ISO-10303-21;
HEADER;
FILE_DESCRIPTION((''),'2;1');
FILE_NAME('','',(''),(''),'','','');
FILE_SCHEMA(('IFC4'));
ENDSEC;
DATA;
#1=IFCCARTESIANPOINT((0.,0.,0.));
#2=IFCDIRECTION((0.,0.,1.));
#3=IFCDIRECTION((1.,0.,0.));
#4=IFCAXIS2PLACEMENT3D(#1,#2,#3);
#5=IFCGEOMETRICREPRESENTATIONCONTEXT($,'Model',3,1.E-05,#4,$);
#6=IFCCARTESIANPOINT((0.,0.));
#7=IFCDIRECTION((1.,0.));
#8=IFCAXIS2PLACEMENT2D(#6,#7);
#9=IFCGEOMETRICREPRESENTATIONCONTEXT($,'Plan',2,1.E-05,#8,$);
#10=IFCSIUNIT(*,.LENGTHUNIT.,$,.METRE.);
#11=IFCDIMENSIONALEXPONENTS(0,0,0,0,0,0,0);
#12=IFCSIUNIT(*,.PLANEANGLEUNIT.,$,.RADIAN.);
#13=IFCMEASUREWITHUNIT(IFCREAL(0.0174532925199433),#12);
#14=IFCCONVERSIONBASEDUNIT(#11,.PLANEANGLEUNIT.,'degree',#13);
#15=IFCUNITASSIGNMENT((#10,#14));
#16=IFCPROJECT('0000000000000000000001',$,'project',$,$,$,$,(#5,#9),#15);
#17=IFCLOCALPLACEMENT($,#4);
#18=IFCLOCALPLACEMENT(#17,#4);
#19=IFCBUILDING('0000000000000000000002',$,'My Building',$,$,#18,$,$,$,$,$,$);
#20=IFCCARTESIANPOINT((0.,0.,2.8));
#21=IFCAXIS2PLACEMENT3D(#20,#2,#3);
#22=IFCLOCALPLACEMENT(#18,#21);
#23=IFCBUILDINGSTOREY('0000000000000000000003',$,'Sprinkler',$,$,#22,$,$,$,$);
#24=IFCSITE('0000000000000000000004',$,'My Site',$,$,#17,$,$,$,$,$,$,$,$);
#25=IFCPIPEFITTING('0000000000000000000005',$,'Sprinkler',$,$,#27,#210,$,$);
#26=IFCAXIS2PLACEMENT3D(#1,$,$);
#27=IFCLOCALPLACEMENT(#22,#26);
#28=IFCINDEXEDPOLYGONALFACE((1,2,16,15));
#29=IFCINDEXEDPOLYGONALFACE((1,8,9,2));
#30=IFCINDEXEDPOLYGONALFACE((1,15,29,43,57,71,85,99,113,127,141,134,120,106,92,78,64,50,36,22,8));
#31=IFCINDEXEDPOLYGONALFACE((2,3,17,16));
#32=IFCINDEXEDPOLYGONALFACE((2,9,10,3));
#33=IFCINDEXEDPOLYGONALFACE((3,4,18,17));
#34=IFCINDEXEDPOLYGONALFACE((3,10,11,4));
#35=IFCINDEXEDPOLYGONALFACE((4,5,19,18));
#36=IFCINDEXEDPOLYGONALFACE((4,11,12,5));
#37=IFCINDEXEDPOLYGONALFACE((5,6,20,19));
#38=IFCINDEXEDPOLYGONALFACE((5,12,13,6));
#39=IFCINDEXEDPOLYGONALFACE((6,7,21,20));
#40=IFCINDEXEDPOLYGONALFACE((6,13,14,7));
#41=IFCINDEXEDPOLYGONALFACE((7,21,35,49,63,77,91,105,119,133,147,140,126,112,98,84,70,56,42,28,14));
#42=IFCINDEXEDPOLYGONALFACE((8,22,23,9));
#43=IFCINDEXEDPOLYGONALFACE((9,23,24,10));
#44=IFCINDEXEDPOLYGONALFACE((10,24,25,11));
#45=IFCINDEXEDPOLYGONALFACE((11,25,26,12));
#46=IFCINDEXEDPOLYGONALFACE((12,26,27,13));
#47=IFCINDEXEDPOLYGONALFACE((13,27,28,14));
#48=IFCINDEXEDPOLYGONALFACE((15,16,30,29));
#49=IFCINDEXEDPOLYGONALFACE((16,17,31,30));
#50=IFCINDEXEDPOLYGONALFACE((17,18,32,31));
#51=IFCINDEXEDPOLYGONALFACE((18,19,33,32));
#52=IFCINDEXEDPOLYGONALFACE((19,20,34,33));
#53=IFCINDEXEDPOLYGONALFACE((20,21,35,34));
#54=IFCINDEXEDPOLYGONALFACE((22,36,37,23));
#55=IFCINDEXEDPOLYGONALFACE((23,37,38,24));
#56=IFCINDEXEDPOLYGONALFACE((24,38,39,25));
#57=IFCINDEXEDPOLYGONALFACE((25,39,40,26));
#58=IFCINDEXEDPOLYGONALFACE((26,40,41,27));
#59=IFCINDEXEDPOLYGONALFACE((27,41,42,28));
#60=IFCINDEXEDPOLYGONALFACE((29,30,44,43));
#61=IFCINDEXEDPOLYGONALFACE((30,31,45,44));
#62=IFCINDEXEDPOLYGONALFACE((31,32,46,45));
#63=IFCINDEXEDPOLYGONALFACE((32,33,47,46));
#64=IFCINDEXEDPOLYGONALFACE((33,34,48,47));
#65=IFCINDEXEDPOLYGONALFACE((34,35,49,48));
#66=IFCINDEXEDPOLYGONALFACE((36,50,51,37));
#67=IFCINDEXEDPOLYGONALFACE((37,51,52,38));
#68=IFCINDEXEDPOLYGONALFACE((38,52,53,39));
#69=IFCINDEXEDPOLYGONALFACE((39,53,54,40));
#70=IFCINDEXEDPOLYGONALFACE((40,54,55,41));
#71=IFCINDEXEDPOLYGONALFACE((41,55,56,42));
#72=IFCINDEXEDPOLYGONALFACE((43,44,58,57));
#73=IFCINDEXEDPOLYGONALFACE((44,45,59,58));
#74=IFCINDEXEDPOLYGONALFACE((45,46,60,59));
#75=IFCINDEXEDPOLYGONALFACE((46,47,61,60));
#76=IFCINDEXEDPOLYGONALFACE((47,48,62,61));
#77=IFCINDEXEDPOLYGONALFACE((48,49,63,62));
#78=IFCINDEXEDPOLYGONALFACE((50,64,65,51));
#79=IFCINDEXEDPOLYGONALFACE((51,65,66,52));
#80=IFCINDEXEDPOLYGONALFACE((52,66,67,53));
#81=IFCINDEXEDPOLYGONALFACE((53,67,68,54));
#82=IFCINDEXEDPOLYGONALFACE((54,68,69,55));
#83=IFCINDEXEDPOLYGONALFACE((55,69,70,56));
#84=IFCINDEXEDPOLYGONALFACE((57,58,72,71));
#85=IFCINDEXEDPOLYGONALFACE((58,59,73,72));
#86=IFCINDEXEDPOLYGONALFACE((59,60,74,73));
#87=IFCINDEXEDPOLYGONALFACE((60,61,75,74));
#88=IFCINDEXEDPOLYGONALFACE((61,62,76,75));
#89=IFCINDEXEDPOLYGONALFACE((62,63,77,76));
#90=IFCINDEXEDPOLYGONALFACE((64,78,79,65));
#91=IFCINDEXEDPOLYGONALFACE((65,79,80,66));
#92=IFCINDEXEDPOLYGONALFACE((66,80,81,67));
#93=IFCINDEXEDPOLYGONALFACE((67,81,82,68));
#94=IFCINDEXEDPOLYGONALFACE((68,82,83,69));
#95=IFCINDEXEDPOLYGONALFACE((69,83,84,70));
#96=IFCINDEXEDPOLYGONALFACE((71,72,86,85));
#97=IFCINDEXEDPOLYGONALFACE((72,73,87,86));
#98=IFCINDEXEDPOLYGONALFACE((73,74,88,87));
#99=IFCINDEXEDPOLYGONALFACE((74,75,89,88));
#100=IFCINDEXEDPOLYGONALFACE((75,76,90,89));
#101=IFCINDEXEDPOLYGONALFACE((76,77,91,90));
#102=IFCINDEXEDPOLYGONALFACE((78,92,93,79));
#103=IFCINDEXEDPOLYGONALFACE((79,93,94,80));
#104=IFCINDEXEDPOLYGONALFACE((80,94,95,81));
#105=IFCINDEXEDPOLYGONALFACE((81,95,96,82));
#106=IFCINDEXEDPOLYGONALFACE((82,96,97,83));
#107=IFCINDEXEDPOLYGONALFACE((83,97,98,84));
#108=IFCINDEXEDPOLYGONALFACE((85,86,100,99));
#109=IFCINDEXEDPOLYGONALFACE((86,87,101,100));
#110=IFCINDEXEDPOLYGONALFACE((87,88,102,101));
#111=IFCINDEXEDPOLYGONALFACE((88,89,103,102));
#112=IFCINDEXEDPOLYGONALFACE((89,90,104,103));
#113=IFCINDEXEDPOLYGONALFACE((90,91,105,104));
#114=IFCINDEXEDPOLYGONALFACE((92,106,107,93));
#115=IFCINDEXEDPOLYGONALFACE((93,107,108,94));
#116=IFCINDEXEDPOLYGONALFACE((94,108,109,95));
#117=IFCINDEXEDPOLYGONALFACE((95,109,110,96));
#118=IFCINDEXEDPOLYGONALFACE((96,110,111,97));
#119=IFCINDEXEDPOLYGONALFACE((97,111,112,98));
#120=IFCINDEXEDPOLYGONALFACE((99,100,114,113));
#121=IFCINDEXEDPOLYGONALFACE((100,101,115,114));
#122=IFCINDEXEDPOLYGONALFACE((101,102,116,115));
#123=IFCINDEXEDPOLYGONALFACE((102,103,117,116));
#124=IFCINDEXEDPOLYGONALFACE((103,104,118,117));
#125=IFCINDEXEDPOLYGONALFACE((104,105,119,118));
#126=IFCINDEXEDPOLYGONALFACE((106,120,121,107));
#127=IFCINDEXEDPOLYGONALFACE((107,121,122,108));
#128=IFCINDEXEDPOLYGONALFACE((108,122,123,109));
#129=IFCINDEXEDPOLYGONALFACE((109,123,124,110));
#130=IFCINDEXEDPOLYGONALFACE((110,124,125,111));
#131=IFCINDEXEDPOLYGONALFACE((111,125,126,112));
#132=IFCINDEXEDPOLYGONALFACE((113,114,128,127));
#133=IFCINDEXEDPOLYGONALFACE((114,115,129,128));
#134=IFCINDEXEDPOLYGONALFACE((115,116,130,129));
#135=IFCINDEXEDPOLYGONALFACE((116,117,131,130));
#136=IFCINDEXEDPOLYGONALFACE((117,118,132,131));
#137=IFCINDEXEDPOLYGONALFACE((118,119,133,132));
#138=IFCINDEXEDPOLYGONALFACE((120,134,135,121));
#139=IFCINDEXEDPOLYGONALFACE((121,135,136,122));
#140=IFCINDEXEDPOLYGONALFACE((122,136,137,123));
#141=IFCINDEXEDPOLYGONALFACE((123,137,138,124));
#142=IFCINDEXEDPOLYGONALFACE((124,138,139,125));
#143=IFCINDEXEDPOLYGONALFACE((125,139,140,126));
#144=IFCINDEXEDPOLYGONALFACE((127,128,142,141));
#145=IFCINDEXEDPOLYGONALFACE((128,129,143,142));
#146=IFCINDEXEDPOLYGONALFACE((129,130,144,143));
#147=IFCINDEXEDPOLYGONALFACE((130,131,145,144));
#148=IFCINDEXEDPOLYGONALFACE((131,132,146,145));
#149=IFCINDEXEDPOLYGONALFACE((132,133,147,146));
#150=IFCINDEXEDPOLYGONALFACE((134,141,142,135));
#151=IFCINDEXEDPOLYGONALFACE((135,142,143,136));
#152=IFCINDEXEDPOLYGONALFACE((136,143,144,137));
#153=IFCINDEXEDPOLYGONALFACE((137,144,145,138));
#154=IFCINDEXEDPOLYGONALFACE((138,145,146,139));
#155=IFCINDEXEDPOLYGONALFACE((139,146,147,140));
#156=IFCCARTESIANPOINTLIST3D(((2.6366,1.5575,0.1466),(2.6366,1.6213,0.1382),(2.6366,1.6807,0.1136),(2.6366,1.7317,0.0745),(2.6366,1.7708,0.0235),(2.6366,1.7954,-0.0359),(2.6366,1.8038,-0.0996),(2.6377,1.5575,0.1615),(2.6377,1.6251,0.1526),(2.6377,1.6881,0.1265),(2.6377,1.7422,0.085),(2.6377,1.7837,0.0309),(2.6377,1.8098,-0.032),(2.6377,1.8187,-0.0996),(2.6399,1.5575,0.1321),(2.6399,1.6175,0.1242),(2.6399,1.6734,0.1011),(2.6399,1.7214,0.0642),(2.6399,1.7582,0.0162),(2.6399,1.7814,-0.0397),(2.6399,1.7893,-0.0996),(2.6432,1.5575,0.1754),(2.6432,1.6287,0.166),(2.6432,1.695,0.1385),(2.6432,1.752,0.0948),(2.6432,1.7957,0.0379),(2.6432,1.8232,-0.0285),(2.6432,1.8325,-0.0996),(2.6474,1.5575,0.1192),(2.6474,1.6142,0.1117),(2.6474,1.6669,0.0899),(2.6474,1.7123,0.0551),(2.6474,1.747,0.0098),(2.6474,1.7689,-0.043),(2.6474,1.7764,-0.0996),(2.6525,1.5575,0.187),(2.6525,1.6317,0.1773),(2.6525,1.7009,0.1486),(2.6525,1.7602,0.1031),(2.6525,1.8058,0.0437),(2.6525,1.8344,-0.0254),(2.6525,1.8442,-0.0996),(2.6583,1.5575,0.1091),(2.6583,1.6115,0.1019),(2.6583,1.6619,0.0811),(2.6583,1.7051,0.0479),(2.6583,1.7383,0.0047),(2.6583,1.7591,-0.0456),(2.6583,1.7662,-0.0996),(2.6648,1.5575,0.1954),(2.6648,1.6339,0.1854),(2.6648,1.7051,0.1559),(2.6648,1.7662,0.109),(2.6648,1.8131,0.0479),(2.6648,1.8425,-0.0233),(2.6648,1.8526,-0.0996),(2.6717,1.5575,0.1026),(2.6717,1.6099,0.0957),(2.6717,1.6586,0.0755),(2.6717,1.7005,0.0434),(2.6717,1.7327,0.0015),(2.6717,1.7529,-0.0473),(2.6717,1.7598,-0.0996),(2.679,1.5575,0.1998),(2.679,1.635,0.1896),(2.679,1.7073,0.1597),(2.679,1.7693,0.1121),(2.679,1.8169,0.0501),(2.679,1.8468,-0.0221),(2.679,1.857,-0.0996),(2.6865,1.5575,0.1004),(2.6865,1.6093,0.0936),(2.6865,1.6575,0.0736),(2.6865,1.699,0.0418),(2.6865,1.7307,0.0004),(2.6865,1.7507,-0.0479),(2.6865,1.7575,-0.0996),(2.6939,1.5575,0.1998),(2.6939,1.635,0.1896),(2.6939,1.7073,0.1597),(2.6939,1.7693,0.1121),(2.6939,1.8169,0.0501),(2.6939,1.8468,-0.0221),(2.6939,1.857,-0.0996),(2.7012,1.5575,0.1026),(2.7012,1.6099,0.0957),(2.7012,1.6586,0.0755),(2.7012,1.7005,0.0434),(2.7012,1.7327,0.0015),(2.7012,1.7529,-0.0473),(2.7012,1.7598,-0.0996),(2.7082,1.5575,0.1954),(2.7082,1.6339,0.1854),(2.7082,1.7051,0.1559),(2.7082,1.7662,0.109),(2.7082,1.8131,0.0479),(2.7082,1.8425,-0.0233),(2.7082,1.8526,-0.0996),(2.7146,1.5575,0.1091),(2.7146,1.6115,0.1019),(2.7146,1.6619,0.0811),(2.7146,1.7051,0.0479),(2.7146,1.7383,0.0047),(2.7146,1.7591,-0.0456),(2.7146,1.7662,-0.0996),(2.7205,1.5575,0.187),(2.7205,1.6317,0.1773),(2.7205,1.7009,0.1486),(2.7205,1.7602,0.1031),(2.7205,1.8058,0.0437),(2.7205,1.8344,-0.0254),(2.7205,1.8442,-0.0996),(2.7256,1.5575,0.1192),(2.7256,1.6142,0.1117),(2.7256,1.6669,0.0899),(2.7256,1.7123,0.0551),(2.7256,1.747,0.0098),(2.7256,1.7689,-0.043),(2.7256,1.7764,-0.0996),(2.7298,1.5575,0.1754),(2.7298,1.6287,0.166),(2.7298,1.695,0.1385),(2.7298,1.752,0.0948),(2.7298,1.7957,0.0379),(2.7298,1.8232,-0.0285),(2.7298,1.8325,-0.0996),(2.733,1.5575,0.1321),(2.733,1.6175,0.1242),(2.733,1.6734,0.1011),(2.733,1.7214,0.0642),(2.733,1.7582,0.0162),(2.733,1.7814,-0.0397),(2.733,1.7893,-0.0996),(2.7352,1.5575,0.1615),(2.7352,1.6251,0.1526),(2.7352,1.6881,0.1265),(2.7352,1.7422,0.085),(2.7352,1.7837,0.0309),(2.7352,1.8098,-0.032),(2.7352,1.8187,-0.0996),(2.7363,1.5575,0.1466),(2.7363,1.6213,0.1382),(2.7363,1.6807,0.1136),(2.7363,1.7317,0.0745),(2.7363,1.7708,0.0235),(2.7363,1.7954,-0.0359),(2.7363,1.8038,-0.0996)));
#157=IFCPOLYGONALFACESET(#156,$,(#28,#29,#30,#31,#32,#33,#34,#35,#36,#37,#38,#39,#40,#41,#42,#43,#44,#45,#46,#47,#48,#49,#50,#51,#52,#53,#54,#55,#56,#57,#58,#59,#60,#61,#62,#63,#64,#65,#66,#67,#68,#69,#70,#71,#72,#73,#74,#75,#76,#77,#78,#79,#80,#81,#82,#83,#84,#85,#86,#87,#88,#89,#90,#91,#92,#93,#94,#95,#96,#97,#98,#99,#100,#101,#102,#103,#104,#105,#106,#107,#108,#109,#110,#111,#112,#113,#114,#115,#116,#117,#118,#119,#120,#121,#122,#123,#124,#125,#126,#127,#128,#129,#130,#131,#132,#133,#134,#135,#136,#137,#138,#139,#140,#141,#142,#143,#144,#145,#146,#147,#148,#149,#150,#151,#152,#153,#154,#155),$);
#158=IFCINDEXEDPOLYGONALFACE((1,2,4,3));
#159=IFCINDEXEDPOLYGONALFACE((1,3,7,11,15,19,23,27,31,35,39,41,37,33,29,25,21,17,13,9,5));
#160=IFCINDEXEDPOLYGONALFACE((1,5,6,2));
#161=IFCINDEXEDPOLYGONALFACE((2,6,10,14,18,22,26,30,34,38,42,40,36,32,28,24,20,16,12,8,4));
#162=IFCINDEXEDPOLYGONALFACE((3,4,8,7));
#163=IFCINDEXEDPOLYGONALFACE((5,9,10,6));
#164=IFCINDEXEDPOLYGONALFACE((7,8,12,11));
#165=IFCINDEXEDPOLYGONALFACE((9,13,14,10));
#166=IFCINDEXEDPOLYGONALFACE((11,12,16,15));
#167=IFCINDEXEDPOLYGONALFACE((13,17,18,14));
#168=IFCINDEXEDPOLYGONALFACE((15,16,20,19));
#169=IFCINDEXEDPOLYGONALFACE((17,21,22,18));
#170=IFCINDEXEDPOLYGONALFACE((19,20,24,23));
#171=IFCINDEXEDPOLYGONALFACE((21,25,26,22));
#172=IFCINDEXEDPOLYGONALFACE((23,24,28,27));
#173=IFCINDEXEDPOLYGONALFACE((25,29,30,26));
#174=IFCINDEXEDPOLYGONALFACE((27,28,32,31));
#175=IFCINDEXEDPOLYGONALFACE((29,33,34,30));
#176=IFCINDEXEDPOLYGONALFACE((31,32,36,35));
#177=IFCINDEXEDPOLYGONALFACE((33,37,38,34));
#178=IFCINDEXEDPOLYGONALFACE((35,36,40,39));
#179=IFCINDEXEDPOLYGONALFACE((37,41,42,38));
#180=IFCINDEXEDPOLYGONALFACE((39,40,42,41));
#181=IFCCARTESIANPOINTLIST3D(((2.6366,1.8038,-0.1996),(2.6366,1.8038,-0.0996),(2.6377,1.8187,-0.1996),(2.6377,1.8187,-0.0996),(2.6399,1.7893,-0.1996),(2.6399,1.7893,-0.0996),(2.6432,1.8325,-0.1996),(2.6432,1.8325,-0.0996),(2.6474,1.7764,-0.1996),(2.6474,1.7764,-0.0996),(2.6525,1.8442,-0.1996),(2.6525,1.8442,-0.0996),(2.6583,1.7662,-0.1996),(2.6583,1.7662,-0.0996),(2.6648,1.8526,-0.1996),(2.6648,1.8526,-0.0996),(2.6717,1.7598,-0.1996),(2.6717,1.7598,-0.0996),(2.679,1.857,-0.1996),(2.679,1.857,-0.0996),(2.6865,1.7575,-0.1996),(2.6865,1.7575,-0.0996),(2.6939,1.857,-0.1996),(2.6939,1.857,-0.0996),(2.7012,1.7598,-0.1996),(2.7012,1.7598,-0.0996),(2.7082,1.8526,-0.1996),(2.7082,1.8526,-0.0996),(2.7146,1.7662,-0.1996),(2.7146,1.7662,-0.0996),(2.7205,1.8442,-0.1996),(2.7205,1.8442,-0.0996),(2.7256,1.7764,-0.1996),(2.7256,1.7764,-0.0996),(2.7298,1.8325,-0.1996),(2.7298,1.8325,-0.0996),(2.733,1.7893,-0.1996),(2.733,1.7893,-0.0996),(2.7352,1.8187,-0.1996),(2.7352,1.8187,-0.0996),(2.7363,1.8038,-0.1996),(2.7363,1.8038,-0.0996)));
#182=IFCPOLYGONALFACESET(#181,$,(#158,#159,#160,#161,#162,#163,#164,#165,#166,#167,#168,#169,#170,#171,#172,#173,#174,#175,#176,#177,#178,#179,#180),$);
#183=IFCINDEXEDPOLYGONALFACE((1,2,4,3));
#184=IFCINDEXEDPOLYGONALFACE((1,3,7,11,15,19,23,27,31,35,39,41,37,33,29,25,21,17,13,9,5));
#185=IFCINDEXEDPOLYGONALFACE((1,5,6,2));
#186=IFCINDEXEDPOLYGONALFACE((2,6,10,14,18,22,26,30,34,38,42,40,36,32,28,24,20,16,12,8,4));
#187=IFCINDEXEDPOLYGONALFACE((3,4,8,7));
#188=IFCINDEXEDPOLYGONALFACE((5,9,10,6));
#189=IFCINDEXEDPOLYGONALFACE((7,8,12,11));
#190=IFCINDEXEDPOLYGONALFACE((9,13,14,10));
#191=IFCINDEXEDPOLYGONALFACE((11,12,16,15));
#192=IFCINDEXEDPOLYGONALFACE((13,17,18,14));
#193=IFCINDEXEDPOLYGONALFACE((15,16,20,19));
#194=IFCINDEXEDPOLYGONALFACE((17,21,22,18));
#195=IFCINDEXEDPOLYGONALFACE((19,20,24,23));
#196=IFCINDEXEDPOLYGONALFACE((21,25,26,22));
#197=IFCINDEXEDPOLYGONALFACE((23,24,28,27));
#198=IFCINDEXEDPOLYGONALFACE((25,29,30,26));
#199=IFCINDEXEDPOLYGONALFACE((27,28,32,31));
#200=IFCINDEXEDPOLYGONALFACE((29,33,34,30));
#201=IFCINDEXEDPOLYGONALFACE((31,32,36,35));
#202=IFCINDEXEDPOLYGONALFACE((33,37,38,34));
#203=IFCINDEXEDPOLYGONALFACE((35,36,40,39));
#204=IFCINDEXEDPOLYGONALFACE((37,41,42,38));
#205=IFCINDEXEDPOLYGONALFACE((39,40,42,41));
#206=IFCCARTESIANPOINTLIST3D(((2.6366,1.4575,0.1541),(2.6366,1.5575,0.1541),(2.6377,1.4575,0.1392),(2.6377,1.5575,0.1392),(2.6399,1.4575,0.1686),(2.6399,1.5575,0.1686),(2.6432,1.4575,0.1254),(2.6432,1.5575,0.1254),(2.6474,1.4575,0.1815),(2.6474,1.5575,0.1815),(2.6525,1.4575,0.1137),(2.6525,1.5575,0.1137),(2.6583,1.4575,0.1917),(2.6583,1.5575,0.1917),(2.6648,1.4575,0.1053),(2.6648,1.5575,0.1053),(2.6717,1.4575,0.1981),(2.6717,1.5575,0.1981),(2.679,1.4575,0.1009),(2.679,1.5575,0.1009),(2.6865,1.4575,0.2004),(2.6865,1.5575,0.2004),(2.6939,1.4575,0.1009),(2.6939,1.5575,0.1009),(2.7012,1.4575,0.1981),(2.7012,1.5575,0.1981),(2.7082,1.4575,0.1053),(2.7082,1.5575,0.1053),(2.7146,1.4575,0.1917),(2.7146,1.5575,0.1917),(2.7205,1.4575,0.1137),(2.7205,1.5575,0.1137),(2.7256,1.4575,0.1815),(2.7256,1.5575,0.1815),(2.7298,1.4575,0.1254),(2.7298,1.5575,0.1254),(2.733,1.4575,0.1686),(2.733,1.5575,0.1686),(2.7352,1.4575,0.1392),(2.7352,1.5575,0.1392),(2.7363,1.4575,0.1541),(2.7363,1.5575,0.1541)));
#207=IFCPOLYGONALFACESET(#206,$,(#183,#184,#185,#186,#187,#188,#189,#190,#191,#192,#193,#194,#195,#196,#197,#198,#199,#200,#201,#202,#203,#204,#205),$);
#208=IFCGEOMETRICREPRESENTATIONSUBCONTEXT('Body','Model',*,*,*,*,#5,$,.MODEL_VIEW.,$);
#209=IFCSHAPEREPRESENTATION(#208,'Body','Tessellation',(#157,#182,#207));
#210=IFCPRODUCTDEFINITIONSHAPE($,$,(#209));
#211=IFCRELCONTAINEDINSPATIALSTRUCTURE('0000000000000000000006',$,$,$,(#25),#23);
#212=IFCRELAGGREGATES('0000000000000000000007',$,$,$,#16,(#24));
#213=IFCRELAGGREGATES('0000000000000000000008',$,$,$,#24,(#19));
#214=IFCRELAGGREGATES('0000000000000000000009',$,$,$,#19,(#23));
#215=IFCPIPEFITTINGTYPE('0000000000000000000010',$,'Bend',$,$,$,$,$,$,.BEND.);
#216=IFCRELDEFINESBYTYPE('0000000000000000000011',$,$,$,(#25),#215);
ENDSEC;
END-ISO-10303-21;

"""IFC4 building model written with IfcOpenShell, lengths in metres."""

from ifc_helpers import new_model, entity, si_unit, converted_unit, frame, origin_with_axes, origin_2d_with_axis, place, context, subcontext, project, spatial, circle, extrude, source, transform, mapped, type_object, type_shapes, element, save


model = new_model("IFC4")

# Units and contexts
model_context = context("Model", 3, precision=1e-05, world=origin_with_axes())
plan_context = context("Plan", 2, precision=1e-05, world=origin_2d_with_axis())
body_context = subcontext(model_context, "Body", "Model", "MODEL_VIEW")
ifc_project = project(units=[si_unit("LENGTHUNIT", "METRE"), converted_unit("PLANEANGLEUNIT", "degree", entity("IfcReal", 0.0174532925199433), si_unit("PLANEANGLEUNIT", "RADIAN"), dimensions=[0, 0, 0, 0, 0, 0, 0])], contexts=[model_context, plan_context])

# Site, building, storey
site_placement = place(None, origin_with_axes())
site = spatial("IfcSite", under=ifc_project, at=site_placement, Name="My Site")
building_placement = place(site_placement, origin_with_axes())
building = spatial("IfcBuilding", under=site, at=building_placement, Name="My Building")
storey_placement = place(building_placement, frame((0.0, 0.0, 2.8), z_axis=(0.0, 0.0, 1.0), x_axis=(1.0, 0.0, 0.0)))
storey = spatial("IfcBuildingStorey", under=building, at=storey_placement, Name="Sprinkler")

# Pipe fitting
pipe_fitting_type_1 = type_object("IfcPipeFittingType", Name="Bend", PredefinedType="BEND")
shared_shape = source(origin_with_axes(), body_context, "Body", "SolidModel", [
    entity("IfcSweptDiskSolid", entity("IfcIndexedPolyCurve", entity("IfcCartesianPointList3D", [[0.0, 0.0, 0.1], [0.0732, 0.0, 0.2768], [0.25, 0.0, 0.35]]), [entity("IfcArcIndex", [1, 2, 3])]), 0.05),
    extrude(circle(Radius=0.05), origin_with_axes(), (0.0, 0.0, 1.0), 0.1),
    extrude(circle(Radius=0.05), frame((0.25, 0.0, 0.35), z_axis=(1.0, 0.0, 0.000001), x_axis=(-0.000001, 0.0, 1.0)), (0.0, 0.0, 1.0), 0.1),
])
type_shapes(pipe_fitting_type_1, [shared_shape])
for number, where, z_axis, x_axis, name in (
    (1, (2.6865, 1.8075, -0.1996), (0.0, -0.000008, 1.0), (0.0, -1.0, -0.000008), "Sprinkler"),
):
    element("IfcPipeFitting", number, at=place(storey_placement, frame(where, z_axis=z_axis, x_axis=x_axis)), inside=storey, type_object=pipe_fitting_type_1, Name=name, context=body_context, shape_type="MappedRepresentation", body=[
        mapped(shared_shape, transform((0.0, 0.0, 0.0), x_axis=(1.0, 0.0, 0.0), y_axis=(0.0, 1.0, 0.0), z_axis=(0.0, 0.0, 1.0), scale=1.0)),
    ])

save(model, "model.ifc")
